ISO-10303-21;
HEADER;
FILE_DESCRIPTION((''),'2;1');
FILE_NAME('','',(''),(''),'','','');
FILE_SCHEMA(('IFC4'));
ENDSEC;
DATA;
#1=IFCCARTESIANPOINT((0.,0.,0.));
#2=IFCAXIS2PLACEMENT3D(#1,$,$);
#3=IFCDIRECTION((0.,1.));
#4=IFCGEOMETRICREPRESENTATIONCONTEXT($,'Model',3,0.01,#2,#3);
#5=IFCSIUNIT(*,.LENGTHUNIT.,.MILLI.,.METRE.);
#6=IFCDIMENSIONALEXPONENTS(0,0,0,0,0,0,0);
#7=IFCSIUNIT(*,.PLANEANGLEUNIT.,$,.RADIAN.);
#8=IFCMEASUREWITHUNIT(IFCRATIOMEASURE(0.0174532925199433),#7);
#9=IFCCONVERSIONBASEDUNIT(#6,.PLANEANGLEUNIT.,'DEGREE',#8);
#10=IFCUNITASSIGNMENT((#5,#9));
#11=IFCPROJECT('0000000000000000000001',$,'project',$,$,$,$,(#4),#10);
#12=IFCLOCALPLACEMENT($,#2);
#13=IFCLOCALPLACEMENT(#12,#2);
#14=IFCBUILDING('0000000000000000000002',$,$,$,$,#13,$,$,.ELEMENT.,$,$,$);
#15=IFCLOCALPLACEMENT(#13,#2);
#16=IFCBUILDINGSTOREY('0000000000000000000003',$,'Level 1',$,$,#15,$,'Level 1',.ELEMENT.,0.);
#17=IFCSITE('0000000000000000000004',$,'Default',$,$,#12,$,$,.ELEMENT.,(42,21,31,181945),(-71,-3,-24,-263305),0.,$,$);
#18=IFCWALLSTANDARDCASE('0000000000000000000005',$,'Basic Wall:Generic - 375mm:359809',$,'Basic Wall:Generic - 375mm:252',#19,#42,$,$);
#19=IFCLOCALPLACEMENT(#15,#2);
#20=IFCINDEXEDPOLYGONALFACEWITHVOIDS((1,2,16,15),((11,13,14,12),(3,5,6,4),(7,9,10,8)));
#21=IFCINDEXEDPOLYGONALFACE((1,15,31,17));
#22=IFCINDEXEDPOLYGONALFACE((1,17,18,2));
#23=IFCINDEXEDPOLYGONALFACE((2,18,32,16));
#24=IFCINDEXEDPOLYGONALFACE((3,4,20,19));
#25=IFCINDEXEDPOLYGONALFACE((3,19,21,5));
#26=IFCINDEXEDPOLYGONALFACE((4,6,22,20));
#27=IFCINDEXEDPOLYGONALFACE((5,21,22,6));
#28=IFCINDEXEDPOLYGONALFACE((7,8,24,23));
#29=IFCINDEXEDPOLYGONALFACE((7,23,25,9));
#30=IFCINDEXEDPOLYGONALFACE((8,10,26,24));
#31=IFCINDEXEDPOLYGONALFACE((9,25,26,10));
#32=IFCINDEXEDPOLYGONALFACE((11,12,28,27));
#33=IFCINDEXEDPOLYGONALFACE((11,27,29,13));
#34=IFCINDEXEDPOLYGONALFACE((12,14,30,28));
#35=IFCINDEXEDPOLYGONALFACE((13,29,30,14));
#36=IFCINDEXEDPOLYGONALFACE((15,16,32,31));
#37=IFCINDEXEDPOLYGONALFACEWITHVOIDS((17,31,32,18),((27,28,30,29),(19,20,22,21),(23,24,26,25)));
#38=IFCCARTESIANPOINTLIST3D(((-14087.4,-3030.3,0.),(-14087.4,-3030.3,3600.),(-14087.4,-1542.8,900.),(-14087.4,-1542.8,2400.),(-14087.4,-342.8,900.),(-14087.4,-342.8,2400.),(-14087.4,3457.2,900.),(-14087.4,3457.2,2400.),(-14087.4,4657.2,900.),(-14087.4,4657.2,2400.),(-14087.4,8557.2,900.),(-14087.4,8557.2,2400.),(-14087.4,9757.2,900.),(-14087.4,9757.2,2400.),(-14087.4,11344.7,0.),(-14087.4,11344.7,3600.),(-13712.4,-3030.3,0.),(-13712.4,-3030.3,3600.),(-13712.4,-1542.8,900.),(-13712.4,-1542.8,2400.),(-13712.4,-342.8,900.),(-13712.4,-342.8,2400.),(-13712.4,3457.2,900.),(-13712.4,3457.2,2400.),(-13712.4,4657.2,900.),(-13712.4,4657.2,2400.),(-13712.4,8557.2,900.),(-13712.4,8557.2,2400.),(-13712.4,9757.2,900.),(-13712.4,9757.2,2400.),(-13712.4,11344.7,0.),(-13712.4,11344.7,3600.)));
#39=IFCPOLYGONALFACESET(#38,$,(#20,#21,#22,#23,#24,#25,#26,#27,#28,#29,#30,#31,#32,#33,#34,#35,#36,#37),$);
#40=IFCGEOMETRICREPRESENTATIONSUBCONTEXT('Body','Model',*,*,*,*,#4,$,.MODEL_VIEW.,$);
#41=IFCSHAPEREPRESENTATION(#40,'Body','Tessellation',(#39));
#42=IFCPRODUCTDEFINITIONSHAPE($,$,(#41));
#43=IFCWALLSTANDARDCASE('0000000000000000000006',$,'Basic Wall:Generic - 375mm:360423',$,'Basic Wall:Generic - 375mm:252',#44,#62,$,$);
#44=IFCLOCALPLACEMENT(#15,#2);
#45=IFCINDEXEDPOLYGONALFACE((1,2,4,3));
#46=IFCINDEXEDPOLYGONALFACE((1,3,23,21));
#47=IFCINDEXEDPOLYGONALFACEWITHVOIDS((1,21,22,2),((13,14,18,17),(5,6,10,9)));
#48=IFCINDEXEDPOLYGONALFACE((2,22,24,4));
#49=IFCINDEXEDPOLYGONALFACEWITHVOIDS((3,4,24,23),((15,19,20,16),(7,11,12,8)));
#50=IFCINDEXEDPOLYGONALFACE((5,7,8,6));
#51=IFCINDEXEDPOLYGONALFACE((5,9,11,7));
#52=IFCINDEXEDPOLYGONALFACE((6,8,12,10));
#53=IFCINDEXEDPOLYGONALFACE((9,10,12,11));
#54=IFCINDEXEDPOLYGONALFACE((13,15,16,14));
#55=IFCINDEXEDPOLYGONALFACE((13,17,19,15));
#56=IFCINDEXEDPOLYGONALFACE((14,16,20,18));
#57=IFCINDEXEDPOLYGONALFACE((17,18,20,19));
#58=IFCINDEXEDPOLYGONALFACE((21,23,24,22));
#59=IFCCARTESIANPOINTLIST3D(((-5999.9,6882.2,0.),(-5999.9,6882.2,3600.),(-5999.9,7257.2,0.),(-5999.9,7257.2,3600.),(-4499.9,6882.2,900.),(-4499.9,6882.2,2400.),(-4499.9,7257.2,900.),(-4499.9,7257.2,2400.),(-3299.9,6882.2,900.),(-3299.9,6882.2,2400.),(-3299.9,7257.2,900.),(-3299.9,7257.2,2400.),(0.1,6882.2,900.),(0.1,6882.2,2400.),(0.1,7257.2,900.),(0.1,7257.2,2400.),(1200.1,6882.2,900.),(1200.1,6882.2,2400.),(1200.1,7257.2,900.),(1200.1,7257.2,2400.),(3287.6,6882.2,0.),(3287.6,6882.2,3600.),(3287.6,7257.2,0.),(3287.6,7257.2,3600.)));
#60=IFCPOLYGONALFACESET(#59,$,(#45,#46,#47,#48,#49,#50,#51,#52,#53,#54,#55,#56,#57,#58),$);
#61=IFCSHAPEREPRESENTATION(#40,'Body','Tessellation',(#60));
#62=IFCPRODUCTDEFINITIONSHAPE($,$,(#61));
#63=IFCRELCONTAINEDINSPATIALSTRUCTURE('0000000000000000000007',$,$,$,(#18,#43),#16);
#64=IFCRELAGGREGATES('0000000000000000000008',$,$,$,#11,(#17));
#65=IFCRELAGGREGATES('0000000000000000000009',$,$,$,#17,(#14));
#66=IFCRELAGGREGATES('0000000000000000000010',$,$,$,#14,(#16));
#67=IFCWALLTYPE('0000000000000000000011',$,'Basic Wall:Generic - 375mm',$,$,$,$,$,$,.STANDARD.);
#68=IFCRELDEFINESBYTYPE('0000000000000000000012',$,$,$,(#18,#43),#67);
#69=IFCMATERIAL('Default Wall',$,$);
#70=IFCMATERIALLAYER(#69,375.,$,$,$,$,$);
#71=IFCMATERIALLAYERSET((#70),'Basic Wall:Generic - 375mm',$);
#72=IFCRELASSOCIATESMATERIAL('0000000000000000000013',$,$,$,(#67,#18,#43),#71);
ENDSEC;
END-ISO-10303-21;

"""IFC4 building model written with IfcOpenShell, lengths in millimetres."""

from ifc_helpers import new_model, entity, si_unit, converted_unit, direction, frame, frame_2d, origin, place, context, subcontext, project, spatial, polyline, rectangle, extrude, clip, bounded_halfspace, material, layer, layer_set, layer_usage, type_object, element, save


model = new_model("IFC4")

# Units and contexts
model_context = context("Model", 3, precision=0.01, world=origin(), true_north=direction((0.0, 1.0)))
body_context = subcontext(model_context, "Body", "Model", "MODEL_VIEW")
ifc_project = project(units=[si_unit("LENGTHUNIT", "METRE", prefix="MILLI"), converted_unit("PLANEANGLEUNIT", "DEGREE", entity("IfcRatioMeasure", 0.0174532925199433), si_unit("PLANEANGLEUNIT", "RADIAN"), dimensions=[0, 0, 0, 0, 0, 0, 0])], contexts=[model_context])

# Site, building, storey
site_placement = place(None, origin())
site = spatial("IfcSite", under=ifc_project, at=site_placement, Name="Default", CompositionType="ELEMENT", RefLatitude=(42, 21, 31, 181945), RefLongitude=(-71, -3, -24, -263305), RefElevation=0.0)
building_placement = place(site_placement, origin())
building = spatial("IfcBuilding", under=site, at=building_placement, CompositionType="ELEMENT")
storey_placement = place(building_placement, origin())
storey = spatial("IfcBuildingStorey", under=building, at=storey_placement, Name="Level 1", LongName="Level 1", CompositionType="ELEMENT", Elevation=0.0)

# Walls, openings
ifc_material_1 = material(Name="Default Wall")
ifc_layer_1 = layer(ifc_material_1, 375.0)
ifc_layer_set_1 = layer_set([ifc_layer_1], Name="Basic Wall:Generic - 375mm")
ifc_layer_usage_1 = layer_usage(ifc_layer_set_1, "AXIS2", "NEGATIVE", 187.5)
wall_type_1 = type_object("IfcWallType", Name="Basic Wall:Generic - 375mm", PredefinedType="STANDARD", material=ifc_layer_set_1)
wall_1_placement = place(storey_placement, frame((-13899.9, 11344.7, 0.0), z_axis=(0.0, 0.0, 1.0), x_axis=(0.0, -1.0, 0.0)))
wall_1 = element("IfcWallStandardCase", 1, at=wall_1_placement, inside=storey, type_object=wall_type_1, material=ifc_layer_usage_1, Name="Basic Wall:Generic - 375mm:359809", ObjectType="Basic Wall:Generic - 375mm:252", context=body_context, shape_type="Clipping", body=[
    clip(extrude(rectangle(XDim=14375.0, YDim=375.0, at=frame_2d((7187.5, 0.0), x_axis=(-1.0, 0.0))), origin(), (0.0, 0.0, 1.0), 3600.0), bounded_halfspace(frame((0.0, -187.5, 3600.0), z_axis=(0.0, 0.0, -1.0), x_axis=(0.0, 1.0, 0.0)), True, frame((0.0, -187.5, 3600.0)), polyline([(0.0, 0.0), (14375.0, 0.0), (14375.0, 375.0), (14000.0, 375.0), (10487.5, 375.0), (10287.5, 375.0), (4287.5, 375.0), (4087.5, 375.0), (375.0, 375.0), (0.0, 375.0), (0.0, 0.0)]))),
])
opening_1_placement = place(wall_1_placement, frame((1587.5, -187.5, 900.0)))
element("IfcOpeningElement", 2, at=opening_1_placement, cuts=wall_1, ObjectType="Opening", context=body_context, shape_type="SweptSolid", body=[
    extrude(rectangle(XDim=1500.0, YDim=1200.0, at=frame_2d((750.0, 600.0), x_axis=(-1.0, 0.0))), frame((0.0, 0.0, 0.0), z_axis=(0.0, 1.0, 0.0), x_axis=(0.0, 0.0, 1.0)), (0.0, 0.0, 1.0), 375.0),
])
opening_2_placement = place(wall_1_placement, frame((6687.5, -187.5, 900.0)))
element("IfcOpeningElement", 3, at=opening_2_placement, cuts=wall_1, ObjectType="Opening", context=body_context, shape_type="SweptSolid", body=[
    extrude(rectangle(XDim=1500.0, YDim=1200.0, at=frame_2d((750.0, 600.0), x_axis=(-1.0, 0.0))), frame((0.0, 0.0, 0.0), z_axis=(0.0, 1.0, 0.0), x_axis=(0.0, 0.0, 1.0)), (0.0, 0.0, 1.0), 375.0),
])
opening_3_placement = place(wall_1_placement, frame((11687.5, -187.5, 900.0)))
element("IfcOpeningElement", 4, at=opening_3_placement, cuts=wall_1, ObjectType="Opening", context=body_context, shape_type="SweptSolid", body=[
    extrude(rectangle(XDim=1500.0, YDim=1200.0, at=frame_2d((750.0, 600.0), x_axis=(-1.0, 0.0))), frame((0.0, 0.0, 0.0), z_axis=(0.0, 1.0, 0.0), x_axis=(0.0, 0.0, 1.0)), (0.0, 0.0, 1.0), 375.0),
])
ifc_layer_usage_2 = layer_usage(ifc_layer_set_1, "AXIS2", "NEGATIVE", 187.5)
wall_2_placement = place(storey_placement, frame((-5999.9, 7069.7, 0.0)))
wall_2 = element("IfcWallStandardCase", 5, at=wall_2_placement, inside=storey, type_object=wall_type_1, material=ifc_layer_usage_2, Name="Basic Wall:Generic - 375mm:360423", ObjectType="Basic Wall:Generic - 375mm:252", context=body_context, shape_type="Clipping", body=[
    clip(extrude(rectangle(XDim=9287.5, YDim=375.0, at=frame_2d((4643.8, 0.0), x_axis=(-1.0, 0.0))), origin(), (0.0, 0.0, 1.0), 3600.0), bounded_halfspace(frame((0.0, -187.5, 3600.0), z_axis=(0.0, 0.0, -1.0), x_axis=(1.0, 0.0, 0.0)), True, frame((0.0, -187.5, 3600.0)), polyline([(0.0, 0.0), (375.0, 0.0), (9287.5, 0.0), (9287.5, 375.0), (8912.5, 375.0), (4200.0, 375.0), (4000.0, 375.0), (0.0, 375.0), (0.0, 175.0), (0.0, 0.0)]))),
])
opening_4_placement = place(wall_2_placement, frame((1500.0, -187.5, 900.0)))
element("IfcOpeningElement", 6, at=opening_4_placement, cuts=wall_2, ObjectType="Opening", context=body_context, shape_type="SweptSolid", body=[
    extrude(rectangle(XDim=1500.0, YDim=1200.0, at=frame_2d((750.0, 600.0), x_axis=(-1.0, 0.0))), frame((0.0, 0.0, 0.0), z_axis=(0.0, 1.0, 0.0), x_axis=(0.0, 0.0, 1.0)), (0.0, 0.0, 1.0), 375.0),
])
opening_5_placement = place(wall_2_placement, frame((6000.0, -187.5, 900.0)))
element("IfcOpeningElement", 7, at=opening_5_placement, cuts=wall_2, ObjectType="Opening", context=body_context, shape_type="SweptSolid", body=[
    extrude(rectangle(XDim=1500.0, YDim=1200.0, at=frame_2d((750.0, 600.0), x_axis=(-1.0, 0.0))), frame((0.0, 0.0, 0.0), z_axis=(0.0, 1.0, 0.0), x_axis=(0.0, 0.0, 1.0)), (0.0, 0.0, 1.0), 375.0),
])

save(model, "model.ifc")
